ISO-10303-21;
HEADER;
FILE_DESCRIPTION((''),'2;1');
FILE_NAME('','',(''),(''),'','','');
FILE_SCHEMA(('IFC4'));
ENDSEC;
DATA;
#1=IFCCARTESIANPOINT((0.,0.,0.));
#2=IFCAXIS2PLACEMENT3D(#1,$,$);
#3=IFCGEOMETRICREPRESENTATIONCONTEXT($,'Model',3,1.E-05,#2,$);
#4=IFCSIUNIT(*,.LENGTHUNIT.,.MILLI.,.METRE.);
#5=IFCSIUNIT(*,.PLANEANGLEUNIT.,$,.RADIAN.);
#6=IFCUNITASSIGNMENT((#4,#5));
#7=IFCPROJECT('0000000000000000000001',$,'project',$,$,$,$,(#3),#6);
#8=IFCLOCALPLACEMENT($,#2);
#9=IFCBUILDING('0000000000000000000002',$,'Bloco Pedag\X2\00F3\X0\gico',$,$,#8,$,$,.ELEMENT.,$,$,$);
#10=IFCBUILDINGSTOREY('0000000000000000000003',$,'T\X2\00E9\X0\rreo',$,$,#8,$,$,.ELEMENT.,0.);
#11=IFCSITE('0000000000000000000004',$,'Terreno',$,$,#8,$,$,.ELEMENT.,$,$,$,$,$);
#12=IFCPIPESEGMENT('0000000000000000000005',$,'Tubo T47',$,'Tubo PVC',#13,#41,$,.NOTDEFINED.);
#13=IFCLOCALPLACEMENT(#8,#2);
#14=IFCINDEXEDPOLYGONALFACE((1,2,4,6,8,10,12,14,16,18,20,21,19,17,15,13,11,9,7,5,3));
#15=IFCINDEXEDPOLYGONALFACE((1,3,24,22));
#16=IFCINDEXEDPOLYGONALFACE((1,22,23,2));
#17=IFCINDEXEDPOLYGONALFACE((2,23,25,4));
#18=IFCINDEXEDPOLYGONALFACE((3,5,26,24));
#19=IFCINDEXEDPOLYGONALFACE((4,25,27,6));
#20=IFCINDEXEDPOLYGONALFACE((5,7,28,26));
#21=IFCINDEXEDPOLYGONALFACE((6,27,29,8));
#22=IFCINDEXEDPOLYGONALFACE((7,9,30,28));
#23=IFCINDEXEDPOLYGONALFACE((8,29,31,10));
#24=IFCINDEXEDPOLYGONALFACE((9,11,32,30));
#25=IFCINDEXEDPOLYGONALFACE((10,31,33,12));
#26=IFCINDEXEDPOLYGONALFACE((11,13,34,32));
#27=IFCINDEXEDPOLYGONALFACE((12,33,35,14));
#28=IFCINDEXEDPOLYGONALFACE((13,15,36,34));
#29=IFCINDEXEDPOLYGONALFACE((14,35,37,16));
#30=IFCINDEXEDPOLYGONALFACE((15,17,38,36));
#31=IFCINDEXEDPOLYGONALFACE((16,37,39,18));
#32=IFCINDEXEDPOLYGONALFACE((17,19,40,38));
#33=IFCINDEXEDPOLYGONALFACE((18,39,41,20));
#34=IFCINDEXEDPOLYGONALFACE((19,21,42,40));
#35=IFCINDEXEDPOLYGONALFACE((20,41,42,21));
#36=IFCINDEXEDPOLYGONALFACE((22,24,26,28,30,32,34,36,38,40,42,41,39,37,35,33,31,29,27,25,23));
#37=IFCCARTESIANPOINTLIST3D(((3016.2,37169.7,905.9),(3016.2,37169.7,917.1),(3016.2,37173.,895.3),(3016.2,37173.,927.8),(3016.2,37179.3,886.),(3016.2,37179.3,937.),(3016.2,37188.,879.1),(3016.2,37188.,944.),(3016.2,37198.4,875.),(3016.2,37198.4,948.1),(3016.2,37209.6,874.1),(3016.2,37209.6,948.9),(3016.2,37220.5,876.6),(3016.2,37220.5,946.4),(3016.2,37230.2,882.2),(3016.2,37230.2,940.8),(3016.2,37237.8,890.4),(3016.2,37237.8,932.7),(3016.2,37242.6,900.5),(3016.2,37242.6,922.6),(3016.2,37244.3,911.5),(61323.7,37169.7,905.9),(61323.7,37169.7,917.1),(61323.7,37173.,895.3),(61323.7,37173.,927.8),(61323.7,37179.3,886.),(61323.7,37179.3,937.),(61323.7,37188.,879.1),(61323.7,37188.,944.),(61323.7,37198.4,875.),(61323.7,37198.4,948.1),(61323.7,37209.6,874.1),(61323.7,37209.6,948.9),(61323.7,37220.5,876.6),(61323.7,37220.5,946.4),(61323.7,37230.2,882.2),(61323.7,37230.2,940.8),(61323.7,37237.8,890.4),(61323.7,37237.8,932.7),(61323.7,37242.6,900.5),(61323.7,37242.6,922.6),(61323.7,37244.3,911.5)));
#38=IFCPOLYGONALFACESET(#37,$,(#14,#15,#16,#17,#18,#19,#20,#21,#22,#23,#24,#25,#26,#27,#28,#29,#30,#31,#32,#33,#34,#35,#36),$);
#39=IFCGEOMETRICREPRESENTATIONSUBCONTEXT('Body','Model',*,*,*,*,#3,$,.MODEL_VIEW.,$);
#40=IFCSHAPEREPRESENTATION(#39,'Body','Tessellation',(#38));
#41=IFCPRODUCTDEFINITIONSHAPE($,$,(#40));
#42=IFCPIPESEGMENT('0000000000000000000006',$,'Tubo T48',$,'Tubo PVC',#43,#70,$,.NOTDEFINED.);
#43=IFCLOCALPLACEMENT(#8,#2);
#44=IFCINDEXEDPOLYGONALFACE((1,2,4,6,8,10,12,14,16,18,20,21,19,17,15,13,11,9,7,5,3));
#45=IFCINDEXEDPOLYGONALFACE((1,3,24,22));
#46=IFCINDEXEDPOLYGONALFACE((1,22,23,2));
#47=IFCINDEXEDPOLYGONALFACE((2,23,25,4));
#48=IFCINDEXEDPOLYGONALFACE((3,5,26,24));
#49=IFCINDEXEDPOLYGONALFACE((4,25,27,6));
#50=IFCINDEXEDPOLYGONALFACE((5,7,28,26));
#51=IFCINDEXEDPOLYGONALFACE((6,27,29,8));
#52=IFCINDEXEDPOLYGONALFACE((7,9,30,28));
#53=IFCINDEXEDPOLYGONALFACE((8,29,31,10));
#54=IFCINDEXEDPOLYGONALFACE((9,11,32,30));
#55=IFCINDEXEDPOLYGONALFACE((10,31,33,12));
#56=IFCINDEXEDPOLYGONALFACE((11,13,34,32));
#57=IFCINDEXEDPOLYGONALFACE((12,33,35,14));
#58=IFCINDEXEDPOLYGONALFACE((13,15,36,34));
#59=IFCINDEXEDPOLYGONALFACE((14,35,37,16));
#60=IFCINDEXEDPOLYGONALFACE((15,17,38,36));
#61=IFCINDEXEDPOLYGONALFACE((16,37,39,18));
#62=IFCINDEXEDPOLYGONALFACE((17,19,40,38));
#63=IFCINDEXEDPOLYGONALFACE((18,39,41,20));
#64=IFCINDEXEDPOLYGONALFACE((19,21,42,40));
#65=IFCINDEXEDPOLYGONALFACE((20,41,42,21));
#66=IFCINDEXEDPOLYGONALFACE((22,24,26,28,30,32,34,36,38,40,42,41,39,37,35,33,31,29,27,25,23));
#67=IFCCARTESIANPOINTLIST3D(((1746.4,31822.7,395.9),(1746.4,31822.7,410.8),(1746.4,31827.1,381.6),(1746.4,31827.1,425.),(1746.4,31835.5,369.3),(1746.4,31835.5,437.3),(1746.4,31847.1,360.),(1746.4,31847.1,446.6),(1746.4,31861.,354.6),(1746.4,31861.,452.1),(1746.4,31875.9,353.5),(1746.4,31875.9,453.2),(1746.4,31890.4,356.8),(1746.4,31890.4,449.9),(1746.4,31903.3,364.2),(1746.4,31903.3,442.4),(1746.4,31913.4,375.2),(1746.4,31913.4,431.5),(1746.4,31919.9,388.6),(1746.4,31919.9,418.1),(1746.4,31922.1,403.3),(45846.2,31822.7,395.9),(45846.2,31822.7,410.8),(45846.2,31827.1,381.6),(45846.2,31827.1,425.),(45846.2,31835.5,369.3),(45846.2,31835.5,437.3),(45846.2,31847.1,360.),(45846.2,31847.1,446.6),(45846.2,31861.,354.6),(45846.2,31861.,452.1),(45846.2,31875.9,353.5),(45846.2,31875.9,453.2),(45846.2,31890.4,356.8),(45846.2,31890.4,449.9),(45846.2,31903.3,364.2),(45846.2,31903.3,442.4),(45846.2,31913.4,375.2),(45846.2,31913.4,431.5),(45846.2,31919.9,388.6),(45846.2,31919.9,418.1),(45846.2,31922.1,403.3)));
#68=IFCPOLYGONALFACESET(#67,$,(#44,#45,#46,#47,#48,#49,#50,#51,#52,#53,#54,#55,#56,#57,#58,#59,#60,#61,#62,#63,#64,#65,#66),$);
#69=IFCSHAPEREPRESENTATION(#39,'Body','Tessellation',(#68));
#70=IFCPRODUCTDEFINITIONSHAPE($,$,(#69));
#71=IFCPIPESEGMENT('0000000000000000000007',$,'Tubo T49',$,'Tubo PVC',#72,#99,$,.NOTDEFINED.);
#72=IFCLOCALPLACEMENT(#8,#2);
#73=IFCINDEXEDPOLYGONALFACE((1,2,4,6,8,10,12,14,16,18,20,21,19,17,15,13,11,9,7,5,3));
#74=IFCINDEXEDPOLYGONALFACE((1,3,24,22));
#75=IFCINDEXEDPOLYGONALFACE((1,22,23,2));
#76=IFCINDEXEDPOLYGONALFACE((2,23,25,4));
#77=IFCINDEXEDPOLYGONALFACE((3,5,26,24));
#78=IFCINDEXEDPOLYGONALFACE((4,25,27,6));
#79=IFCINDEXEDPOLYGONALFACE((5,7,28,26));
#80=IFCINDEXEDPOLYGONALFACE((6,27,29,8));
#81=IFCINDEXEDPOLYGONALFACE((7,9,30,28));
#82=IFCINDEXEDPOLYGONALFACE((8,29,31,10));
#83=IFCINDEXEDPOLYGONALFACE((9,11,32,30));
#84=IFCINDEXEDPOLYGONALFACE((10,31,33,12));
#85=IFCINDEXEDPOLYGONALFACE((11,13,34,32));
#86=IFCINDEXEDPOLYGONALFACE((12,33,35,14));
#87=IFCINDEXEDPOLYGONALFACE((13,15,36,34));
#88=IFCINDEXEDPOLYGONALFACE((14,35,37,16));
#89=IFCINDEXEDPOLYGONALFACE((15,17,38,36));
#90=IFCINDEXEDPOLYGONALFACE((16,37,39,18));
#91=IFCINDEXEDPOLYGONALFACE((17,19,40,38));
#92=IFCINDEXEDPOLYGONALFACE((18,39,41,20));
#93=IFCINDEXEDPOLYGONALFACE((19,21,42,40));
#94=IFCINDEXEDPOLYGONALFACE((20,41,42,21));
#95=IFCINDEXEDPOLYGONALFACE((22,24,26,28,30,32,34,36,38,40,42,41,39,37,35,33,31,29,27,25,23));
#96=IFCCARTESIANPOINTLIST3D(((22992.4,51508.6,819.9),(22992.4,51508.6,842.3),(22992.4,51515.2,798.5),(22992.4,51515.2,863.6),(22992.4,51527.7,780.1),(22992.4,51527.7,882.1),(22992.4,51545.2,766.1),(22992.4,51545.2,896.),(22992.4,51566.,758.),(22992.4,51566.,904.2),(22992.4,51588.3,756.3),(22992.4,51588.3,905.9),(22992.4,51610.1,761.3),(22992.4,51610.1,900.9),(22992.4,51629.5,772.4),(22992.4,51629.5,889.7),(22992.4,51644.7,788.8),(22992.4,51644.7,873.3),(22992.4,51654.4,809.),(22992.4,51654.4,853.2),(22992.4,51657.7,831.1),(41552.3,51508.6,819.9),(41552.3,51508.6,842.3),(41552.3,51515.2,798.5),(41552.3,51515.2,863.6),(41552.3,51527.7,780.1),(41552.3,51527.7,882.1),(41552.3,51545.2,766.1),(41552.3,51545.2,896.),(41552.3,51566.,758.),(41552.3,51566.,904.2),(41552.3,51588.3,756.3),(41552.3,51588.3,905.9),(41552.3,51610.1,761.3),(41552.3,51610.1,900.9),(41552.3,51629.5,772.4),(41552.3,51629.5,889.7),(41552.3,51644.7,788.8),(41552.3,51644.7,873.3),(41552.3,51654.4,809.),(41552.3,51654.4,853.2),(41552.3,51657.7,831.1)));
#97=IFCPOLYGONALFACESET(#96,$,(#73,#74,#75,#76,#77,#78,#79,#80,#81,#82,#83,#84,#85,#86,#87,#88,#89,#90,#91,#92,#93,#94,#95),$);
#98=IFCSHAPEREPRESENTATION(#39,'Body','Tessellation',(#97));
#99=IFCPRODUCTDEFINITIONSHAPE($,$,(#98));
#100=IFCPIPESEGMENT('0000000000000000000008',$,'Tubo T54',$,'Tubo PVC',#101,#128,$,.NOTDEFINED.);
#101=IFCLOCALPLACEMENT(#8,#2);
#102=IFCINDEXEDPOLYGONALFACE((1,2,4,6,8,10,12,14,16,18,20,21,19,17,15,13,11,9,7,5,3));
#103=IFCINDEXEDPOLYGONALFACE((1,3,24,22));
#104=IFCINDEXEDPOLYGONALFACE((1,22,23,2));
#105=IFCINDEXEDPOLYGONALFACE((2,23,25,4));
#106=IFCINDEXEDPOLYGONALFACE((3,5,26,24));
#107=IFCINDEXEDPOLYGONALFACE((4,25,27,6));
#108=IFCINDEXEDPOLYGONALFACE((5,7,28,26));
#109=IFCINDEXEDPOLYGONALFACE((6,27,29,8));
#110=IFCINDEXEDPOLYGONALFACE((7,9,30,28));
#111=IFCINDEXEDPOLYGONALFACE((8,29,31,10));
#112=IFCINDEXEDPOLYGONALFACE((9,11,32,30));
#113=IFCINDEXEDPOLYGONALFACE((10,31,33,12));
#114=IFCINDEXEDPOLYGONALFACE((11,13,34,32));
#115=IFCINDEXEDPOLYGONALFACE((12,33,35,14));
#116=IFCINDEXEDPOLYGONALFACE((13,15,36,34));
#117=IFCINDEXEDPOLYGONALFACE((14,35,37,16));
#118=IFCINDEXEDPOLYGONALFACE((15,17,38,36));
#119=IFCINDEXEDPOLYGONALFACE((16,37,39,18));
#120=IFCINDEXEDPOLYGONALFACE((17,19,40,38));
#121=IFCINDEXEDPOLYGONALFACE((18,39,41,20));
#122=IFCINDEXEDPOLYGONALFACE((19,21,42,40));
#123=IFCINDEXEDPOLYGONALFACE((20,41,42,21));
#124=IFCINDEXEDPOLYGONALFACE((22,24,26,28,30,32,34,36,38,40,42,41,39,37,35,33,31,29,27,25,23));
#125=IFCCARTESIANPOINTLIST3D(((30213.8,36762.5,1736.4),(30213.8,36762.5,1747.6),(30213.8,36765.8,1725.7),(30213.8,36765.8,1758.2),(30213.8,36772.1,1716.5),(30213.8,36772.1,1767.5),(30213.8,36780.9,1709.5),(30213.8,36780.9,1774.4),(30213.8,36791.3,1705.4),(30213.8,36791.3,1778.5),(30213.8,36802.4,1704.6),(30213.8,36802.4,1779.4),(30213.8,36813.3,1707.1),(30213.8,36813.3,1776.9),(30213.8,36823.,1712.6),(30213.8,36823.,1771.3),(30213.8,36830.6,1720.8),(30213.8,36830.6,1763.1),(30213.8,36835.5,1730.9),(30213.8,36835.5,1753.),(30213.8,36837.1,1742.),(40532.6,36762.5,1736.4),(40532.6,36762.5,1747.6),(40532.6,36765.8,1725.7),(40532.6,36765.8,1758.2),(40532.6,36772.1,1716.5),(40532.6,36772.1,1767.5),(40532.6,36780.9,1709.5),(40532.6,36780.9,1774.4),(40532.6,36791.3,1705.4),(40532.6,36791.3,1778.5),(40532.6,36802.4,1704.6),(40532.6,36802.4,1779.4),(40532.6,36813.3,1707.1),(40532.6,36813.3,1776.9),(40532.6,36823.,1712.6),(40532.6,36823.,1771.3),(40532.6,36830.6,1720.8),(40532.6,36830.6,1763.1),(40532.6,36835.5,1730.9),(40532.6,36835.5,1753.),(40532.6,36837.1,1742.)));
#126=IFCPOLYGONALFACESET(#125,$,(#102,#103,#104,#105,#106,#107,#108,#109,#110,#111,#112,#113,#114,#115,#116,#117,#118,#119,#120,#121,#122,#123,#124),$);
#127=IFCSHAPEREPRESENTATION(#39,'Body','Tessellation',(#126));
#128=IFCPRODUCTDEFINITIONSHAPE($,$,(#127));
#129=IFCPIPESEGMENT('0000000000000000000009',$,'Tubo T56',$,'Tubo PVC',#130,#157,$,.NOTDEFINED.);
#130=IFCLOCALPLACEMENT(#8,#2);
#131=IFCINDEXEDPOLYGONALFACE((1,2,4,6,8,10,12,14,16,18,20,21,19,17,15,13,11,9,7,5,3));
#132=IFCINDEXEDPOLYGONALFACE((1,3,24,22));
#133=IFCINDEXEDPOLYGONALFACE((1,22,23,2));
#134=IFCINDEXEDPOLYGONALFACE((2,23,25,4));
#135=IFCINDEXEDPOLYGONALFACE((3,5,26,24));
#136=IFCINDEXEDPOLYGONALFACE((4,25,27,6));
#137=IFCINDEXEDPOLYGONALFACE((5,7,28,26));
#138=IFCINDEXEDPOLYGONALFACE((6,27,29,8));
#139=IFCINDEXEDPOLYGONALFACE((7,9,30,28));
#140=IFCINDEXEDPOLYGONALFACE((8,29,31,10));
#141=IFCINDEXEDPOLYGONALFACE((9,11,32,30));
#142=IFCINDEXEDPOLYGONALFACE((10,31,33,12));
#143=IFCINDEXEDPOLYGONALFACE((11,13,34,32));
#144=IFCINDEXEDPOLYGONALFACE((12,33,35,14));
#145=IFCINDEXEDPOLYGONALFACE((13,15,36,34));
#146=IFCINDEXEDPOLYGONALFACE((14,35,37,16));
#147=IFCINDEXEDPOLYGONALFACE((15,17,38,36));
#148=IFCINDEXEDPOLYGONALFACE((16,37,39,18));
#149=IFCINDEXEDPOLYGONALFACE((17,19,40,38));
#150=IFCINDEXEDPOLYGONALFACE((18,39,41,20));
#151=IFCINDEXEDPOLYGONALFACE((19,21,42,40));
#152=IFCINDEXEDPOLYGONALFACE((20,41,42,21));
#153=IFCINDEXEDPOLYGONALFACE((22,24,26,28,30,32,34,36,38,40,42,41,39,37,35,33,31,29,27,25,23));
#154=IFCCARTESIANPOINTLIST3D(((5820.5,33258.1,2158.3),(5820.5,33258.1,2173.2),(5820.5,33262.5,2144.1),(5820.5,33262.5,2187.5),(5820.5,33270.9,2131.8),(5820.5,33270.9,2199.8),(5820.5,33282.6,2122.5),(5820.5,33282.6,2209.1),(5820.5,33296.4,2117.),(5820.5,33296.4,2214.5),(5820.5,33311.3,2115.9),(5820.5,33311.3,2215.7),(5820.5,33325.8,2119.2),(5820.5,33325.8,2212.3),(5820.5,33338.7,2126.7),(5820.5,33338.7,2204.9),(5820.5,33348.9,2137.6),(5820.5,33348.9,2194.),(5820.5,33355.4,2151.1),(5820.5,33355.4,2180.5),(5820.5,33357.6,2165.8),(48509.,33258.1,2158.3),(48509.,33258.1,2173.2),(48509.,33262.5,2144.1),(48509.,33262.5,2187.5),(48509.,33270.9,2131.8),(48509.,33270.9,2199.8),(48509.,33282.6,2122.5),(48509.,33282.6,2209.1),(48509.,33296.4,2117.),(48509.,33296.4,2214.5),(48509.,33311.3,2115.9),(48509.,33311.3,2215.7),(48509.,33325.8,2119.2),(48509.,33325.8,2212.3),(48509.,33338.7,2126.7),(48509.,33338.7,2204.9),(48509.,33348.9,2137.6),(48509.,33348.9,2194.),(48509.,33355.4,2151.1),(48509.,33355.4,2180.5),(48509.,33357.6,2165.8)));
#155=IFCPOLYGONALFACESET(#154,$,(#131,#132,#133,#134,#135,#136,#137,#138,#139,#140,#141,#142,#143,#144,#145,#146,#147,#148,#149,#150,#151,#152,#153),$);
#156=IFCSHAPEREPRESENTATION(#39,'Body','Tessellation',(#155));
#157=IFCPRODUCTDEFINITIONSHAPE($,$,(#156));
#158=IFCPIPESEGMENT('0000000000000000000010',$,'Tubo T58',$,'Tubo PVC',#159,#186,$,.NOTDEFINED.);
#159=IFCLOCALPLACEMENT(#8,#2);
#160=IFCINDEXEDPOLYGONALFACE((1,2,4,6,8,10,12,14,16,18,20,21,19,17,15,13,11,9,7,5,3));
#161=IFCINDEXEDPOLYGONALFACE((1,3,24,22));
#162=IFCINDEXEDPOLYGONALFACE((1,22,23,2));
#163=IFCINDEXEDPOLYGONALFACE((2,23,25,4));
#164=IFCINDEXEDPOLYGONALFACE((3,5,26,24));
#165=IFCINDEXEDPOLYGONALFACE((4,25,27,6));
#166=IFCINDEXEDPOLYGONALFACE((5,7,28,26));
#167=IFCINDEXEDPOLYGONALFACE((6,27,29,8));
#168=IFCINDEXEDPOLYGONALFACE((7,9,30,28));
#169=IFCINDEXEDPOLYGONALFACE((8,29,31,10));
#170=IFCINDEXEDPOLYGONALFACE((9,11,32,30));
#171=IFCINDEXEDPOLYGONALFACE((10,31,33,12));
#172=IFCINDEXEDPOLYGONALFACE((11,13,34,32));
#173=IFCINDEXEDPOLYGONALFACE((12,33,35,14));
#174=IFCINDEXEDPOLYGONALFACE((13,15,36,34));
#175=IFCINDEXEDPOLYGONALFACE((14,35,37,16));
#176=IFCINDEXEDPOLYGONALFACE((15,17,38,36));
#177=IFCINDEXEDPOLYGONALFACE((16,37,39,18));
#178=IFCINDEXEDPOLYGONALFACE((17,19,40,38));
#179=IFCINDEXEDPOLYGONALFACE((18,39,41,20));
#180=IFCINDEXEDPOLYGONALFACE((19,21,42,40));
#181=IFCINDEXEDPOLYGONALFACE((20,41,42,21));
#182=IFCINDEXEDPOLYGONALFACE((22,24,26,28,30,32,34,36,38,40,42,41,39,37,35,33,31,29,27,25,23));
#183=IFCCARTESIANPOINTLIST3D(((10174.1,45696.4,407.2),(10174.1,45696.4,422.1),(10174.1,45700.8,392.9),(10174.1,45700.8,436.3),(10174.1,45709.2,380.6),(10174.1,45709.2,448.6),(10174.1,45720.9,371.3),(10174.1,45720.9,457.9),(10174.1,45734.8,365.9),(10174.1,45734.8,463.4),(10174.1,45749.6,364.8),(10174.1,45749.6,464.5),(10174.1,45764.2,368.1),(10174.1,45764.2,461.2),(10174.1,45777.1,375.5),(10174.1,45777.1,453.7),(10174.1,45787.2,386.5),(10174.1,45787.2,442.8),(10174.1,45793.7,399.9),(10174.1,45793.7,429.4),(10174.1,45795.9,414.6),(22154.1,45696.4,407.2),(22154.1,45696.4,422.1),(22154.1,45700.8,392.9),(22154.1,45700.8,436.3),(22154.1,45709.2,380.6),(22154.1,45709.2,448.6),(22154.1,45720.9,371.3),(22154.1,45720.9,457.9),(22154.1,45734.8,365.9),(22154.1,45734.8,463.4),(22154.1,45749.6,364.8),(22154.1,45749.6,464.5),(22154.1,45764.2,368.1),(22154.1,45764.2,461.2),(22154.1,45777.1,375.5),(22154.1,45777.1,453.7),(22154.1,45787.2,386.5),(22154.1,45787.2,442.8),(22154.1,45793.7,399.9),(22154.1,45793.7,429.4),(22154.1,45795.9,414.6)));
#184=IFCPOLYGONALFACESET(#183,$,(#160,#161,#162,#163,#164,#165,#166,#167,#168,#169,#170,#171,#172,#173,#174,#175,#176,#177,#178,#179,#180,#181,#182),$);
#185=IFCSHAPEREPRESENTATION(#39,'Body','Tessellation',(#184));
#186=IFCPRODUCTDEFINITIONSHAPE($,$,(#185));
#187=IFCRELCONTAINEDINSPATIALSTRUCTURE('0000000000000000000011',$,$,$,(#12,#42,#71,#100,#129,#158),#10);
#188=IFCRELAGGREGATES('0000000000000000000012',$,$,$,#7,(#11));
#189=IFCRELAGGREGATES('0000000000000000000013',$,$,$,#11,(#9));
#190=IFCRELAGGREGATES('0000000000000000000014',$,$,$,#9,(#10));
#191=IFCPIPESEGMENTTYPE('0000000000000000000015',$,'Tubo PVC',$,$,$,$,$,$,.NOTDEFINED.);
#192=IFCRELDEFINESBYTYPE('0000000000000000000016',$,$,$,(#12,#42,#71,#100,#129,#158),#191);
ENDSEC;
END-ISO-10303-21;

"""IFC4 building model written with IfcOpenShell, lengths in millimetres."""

from ifc_helpers import new_model, si_unit, frame, origin, origin_2d, place, context, subcontext, project, spatial, circle, extrude, type_object, element, save


model = new_model("IFC4")

# Units and contexts
model_context = context("Model", 3, precision=1e-05, world=origin())
body_context = subcontext(model_context, "Body", "Model", "MODEL_VIEW")
ifc_project = project(units=[si_unit("LENGTHUNIT", "METRE", prefix="MILLI"), si_unit("PLANEANGLEUNIT", "RADIAN")], contexts=[model_context])

# Site, building, storey
placement = place(None, origin())
site = spatial("IfcSite", under=ifc_project, at=placement, Name="Terreno", CompositionType="ELEMENT")
building = spatial("IfcBuilding", under=site, at=placement, Name="Bloco Pedagógico", CompositionType="ELEMENT")
storey = spatial("IfcBuildingStorey", under=building, at=placement, Name="Térreo", CompositionType="ELEMENT", Elevation=0.0)

# Pipe segments
pipe_segment_type = type_object("IfcPipeSegmentType", Name="Tubo PVC", PredefinedType="NOTDEFINED")
pipe_segment_1_placement = place(None, frame((3016.2, 37206.8, 911.5), z_axis=(1.0, 0.0, 0.0), x_axis=(0.0, 1.0, 0.0)))
element("IfcPipeSegment", 1, at=pipe_segment_1_placement, inside=storey, type_object=pipe_segment_type, Name="Tubo T47", ObjectType="Tubo PVC", PredefinedType="NOTDEFINED", context=body_context, shape_type="SweptSolid", body=[
    extrude(circle(Radius=37.5, at=origin_2d()), None, (0.0, 0.0, 1.0), 58307.5),
])
pipe_segment_2_placement = place(None, frame((1746.4, 31872.1, 403.3), z_axis=(1.0, 0.0, 0.0), x_axis=(0.0, 1.0, 0.0)))
element("IfcPipeSegment", 2, at=pipe_segment_2_placement, inside=storey, type_object=pipe_segment_type, Name="Tubo T48", ObjectType="Tubo PVC", PredefinedType="NOTDEFINED", context=body_context, shape_type="SweptSolid", body=[
    extrude(circle(Radius=50.0, at=origin_2d()), None, (0.0, 0.0, 1.0), 44099.8),
])
pipe_segment_3_placement = place(None, frame((22992.4, 51582.7, 831.1), z_axis=(1.0, 0.0, 0.0), x_axis=(0.0, 1.0, 0.0)))
element("IfcPipeSegment", 3, at=pipe_segment_3_placement, inside=storey, type_object=pipe_segment_type, Name="Tubo T49", ObjectType="Tubo PVC", PredefinedType="NOTDEFINED", context=body_context, shape_type="SweptSolid", body=[
    extrude(circle(Radius=75.0, at=origin_2d()), None, (0.0, 0.0, 1.0), 18559.8),
])
pipe_segment_4_placement = place(None, frame((30213.8, 36799.6, 1742.0), z_axis=(1.0, 0.0, 0.0), x_axis=(0.0, 1.0, 0.0)))
element("IfcPipeSegment", 4, at=pipe_segment_4_placement, inside=storey, type_object=pipe_segment_type, Name="Tubo T54", ObjectType="Tubo PVC", PredefinedType="NOTDEFINED", context=body_context, shape_type="SweptSolid", body=[
    extrude(circle(Radius=37.5, at=origin_2d()), None, (0.0, 0.0, 1.0), 10318.8),
])
pipe_segment_5_placement = place(None, frame((5820.5, 33307.6, 2165.8), z_axis=(1.0, 0.0, 0.0), x_axis=(0.0, 1.0, 0.0)))
element("IfcPipeSegment", 5, at=pipe_segment_5_placement, inside=storey, type_object=pipe_segment_type, Name="Tubo T56", ObjectType="Tubo PVC", PredefinedType="NOTDEFINED", context=body_context, shape_type="SweptSolid", body=[
    extrude(circle(Radius=50.0, at=origin_2d()), None, (0.0, 0.0, 1.0), 42688.5),
])
pipe_segment_6_placement = place(None, frame((10174.1, 45745.9, 414.6), z_axis=(1.0, 0.0, 0.0), x_axis=(0.0, 1.0, 0.0)))
element("IfcPipeSegment", 6, at=pipe_segment_6_placement, inside=storey, type_object=pipe_segment_type, Name="Tubo T58", ObjectType="Tubo PVC", PredefinedType="NOTDEFINED", context=body_context, shape_type="SweptSolid", body=[
    extrude(circle(Radius=50.0, at=origin_2d()), None, (0.0, 0.0, 1.0), 11980.0),
])

save(model, "model.ifc")
